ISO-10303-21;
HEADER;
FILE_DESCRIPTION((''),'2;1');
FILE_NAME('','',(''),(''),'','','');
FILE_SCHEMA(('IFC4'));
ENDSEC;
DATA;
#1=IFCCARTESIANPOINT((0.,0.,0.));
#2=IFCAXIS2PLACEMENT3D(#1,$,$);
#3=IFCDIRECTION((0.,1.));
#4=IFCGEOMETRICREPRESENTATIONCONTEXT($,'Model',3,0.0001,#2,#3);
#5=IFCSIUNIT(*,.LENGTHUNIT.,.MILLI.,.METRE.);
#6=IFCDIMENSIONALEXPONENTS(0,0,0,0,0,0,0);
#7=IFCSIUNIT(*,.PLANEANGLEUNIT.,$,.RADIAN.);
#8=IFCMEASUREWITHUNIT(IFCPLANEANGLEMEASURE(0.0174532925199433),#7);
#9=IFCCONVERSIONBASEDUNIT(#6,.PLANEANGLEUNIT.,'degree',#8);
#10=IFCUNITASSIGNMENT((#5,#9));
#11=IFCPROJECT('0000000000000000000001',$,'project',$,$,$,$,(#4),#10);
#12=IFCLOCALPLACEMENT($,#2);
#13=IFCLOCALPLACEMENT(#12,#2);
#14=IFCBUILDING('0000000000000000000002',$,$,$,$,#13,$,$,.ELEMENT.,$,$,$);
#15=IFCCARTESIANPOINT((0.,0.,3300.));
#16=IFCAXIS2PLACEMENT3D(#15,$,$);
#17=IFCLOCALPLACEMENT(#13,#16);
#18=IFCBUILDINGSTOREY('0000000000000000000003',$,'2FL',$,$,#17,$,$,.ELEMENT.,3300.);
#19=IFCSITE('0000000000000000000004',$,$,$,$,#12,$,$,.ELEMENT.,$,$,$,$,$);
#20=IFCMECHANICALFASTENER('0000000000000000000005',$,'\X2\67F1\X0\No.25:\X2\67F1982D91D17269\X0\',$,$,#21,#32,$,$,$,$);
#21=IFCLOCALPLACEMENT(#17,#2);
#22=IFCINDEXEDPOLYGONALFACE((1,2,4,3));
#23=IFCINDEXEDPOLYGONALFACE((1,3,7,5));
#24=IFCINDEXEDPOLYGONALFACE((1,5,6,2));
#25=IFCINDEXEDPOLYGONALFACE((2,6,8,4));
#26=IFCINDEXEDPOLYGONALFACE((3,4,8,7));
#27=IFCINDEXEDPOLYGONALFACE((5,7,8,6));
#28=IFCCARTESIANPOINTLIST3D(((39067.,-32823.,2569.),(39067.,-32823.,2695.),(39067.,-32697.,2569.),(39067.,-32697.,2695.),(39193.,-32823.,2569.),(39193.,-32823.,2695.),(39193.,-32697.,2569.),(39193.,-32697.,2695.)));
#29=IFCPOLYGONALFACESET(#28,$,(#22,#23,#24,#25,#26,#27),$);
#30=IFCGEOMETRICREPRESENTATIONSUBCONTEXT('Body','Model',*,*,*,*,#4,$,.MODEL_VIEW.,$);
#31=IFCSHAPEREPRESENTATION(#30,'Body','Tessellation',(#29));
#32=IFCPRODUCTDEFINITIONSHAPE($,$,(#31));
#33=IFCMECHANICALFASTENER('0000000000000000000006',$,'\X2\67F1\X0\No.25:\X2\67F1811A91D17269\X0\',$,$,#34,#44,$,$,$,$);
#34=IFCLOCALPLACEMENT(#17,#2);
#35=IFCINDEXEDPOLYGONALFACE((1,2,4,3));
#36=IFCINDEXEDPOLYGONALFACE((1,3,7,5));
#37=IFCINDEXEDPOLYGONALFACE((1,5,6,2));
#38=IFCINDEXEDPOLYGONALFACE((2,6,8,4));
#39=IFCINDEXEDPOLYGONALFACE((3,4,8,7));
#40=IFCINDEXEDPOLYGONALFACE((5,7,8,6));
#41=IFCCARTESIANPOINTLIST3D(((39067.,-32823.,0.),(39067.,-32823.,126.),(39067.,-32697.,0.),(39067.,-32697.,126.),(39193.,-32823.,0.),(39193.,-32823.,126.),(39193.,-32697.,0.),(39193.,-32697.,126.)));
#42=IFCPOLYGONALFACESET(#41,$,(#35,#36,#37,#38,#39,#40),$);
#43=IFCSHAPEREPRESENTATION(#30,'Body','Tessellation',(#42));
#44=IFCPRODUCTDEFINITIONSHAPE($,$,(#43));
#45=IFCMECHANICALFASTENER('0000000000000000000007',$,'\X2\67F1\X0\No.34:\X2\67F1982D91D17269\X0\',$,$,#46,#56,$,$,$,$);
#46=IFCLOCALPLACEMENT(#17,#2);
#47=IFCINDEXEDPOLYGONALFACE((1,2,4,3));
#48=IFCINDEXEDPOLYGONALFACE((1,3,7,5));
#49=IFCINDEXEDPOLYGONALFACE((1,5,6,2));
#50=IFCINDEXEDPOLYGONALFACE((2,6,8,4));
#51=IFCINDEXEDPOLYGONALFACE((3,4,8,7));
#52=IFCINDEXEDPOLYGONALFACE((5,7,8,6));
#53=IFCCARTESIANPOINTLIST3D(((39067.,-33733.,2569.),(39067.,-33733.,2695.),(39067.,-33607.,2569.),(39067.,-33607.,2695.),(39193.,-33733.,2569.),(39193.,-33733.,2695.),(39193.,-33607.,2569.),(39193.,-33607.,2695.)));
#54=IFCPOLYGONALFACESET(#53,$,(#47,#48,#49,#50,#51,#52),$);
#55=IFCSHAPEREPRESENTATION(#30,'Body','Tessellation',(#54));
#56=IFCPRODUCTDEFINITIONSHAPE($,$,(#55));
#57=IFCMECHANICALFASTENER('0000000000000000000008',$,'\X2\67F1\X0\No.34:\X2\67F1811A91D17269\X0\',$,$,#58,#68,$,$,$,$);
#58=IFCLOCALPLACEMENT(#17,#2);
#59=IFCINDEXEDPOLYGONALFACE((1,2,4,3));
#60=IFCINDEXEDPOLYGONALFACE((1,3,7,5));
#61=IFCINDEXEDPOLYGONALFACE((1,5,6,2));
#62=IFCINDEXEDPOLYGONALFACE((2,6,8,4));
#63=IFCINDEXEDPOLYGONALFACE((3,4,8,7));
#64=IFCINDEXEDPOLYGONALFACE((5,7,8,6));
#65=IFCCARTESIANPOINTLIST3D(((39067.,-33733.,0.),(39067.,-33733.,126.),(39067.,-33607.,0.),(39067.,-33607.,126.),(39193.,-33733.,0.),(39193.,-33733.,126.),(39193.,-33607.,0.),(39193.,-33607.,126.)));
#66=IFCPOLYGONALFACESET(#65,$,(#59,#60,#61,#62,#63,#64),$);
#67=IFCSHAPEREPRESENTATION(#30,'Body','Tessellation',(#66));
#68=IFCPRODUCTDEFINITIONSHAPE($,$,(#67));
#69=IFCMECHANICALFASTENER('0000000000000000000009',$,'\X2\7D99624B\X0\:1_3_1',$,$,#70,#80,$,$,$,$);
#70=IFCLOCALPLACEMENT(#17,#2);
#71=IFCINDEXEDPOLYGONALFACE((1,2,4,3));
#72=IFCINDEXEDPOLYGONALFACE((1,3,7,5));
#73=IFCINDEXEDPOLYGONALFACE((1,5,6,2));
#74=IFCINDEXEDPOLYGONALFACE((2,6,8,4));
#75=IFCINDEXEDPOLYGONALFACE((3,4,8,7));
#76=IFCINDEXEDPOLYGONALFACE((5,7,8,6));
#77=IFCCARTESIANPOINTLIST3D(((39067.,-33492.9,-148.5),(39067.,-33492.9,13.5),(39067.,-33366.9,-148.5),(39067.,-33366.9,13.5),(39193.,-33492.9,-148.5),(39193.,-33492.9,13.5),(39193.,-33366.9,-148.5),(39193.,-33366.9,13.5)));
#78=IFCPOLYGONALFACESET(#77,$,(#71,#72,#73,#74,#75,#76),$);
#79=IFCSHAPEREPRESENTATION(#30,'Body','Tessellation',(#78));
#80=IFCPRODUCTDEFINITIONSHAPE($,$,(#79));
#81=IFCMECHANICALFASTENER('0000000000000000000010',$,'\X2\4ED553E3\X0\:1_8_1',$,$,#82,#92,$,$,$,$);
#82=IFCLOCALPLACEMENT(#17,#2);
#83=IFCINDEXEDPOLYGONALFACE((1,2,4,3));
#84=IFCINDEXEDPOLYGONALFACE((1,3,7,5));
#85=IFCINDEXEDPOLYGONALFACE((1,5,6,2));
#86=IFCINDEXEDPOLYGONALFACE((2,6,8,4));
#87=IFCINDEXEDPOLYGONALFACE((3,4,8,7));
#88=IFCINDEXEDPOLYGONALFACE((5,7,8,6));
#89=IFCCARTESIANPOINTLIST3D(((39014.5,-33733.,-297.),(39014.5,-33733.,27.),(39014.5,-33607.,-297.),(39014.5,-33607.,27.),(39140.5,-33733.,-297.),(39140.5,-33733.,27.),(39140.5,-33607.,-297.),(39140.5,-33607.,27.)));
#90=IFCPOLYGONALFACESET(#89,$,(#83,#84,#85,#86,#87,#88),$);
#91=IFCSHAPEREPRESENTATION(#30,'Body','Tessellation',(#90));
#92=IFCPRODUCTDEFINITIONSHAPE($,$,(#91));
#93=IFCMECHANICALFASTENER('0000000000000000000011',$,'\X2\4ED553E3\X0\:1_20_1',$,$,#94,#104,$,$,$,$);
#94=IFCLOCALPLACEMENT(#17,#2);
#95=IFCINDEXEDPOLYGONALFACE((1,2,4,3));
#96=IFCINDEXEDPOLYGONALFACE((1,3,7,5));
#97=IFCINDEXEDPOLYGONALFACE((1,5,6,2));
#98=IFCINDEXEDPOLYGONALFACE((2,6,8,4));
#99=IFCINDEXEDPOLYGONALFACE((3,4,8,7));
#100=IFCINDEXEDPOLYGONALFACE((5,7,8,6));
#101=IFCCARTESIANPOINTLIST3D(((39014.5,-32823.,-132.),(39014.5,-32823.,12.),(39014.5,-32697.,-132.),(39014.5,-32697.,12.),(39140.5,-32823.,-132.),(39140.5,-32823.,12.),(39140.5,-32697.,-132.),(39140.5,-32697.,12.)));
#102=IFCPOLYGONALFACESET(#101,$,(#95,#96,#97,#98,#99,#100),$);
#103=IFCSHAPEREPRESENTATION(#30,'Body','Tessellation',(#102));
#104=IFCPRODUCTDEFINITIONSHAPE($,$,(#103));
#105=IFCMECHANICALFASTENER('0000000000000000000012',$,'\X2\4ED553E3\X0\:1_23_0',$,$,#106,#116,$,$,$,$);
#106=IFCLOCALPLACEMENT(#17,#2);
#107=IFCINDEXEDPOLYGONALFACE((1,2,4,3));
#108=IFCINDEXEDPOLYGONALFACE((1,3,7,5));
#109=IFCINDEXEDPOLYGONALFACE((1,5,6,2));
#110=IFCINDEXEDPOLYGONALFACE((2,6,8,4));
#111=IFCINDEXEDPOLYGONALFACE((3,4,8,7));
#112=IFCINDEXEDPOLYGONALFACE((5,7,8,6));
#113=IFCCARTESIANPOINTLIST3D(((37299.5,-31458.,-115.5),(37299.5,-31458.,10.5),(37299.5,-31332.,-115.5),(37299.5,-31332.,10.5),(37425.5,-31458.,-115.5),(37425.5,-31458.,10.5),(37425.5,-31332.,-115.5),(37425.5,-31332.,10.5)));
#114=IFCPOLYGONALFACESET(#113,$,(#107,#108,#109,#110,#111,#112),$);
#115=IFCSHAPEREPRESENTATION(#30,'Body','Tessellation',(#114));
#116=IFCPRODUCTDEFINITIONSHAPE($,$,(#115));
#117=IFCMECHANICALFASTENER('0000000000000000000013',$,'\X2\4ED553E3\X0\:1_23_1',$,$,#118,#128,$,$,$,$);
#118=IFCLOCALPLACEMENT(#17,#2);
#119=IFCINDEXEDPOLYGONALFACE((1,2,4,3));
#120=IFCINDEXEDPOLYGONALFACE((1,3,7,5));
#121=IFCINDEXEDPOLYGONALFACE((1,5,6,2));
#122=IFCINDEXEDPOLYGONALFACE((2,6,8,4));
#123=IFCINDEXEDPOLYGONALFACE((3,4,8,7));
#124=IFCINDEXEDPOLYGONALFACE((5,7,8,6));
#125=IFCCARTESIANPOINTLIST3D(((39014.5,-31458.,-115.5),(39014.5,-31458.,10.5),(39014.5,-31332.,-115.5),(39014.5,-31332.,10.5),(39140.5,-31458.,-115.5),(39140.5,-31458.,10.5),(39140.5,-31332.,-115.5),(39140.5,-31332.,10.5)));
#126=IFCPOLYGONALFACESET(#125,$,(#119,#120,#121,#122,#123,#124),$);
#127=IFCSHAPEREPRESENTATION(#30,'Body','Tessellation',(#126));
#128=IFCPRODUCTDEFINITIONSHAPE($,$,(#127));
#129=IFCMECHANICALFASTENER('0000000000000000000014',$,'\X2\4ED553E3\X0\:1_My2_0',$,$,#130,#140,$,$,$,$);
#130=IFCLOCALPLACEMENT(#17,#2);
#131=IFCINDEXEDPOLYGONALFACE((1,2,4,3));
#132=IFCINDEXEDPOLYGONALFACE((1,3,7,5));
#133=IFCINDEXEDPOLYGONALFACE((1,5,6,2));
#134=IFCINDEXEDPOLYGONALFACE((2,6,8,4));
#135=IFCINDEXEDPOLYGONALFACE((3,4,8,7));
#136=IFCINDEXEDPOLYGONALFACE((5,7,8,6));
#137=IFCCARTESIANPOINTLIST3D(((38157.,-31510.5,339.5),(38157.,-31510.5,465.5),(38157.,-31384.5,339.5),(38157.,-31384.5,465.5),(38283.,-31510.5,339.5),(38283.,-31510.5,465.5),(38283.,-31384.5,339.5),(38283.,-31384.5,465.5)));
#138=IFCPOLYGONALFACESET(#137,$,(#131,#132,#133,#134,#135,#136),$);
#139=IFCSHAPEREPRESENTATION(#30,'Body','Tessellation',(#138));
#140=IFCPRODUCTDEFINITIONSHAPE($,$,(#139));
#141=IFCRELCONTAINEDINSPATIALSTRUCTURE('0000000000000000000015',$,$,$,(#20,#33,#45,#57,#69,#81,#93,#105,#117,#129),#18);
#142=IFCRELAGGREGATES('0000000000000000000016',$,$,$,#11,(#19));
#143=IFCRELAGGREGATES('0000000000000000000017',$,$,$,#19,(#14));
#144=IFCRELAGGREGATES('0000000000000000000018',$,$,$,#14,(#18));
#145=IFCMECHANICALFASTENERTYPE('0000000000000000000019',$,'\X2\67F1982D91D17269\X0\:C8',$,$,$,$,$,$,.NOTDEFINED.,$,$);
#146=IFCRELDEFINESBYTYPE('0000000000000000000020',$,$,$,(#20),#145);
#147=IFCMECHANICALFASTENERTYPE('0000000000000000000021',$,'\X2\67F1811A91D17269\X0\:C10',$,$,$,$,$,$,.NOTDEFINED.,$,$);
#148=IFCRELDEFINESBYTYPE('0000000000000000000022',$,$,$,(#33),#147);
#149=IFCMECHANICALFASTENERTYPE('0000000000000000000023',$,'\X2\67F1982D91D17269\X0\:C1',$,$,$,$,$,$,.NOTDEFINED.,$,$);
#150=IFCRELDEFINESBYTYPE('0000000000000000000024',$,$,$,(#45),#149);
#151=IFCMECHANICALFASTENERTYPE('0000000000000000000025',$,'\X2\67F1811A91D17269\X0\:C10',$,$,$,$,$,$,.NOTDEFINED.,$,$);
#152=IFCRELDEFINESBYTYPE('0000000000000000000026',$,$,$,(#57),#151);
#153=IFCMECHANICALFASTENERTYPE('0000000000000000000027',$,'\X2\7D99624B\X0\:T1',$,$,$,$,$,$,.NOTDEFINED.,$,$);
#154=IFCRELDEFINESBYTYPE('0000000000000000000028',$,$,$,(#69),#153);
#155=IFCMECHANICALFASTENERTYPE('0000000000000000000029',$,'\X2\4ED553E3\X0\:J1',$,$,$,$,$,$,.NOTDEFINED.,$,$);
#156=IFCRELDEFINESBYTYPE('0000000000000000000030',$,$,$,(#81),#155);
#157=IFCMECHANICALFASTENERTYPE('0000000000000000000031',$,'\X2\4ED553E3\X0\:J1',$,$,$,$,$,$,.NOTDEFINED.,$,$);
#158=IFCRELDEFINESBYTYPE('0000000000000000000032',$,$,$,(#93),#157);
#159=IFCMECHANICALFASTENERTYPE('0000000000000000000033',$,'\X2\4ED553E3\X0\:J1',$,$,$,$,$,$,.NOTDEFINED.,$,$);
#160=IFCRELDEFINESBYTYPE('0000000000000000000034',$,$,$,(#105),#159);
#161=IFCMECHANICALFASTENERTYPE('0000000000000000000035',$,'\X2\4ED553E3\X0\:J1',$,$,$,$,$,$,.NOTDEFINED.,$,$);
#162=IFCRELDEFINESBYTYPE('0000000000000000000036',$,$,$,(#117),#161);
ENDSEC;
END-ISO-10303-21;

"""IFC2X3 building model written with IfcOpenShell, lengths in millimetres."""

from ifc_helpers import new_model, entity, si_unit, converted_unit, direction, frame, origin, origin_with_axes, origin_2d, place, context, subcontext, project, spatial, rectangle, extrude, type_object, element, save


model = new_model("IFC2X3")

# Units and contexts
model_context = context("Model", 3, precision=0.0001, world=origin(), true_north=direction((0.0, 1.0)))
body_context = subcontext(model_context, "Body", "Model", "MODEL_VIEW")
ifc_project = project(units=[si_unit("LENGTHUNIT", "METRE", prefix="MILLI"), converted_unit("PLANEANGLEUNIT", "degree", entity("IfcPlaneAngleMeasure", 0.0174532925199433), si_unit("PLANEANGLEUNIT", "RADIAN"), dimensions=[0, 0, 0, 0, 0, 0, 0])], contexts=[model_context])

# Site, building, storey
site_placement = place(None, origin())
site = spatial("IfcSite", under=ifc_project, at=site_placement, CompositionType="ELEMENT")
building_placement = place(site_placement, origin())
building = spatial("IfcBuilding", under=site, at=building_placement, CompositionType="ELEMENT")
storey_placement = place(building_placement, frame((0.0, 0.0, 3300.0)))
storey = spatial("IfcBuildingStorey", under=building, at=storey_placement, Name="2FL", CompositionType="ELEMENT", Elevation=3300.0)

# Mechanical fasteners
mechanical_fastener_type_1 = type_object("IfcMechanicalFastenerType", Name="柱頭金物:C8")
mechanical_fastener_1_placement = place(storey_placement, frame((39130.0, -32760.0, 2569.0)))
element("IfcMechanicalFastener", 1, at=mechanical_fastener_1_placement, inside=storey, type_object=mechanical_fastener_type_1, Name="柱No.25:柱頭金物", context=body_context, shape_type="SweptSolid", body=[
    extrude(rectangle(XDim=126.0, YDim=126.0, at=origin_2d()), origin_with_axes(), (0.0, 0.0, 1.0), 126.0),
])
mechanical_fastener_type_2 = type_object("IfcMechanicalFastenerType", Name="柱脚金物:C10")
mechanical_fastener_2_placement = place(storey_placement, frame((39130.0, -32760.0, 0.0)))
element("IfcMechanicalFastener", 2, at=mechanical_fastener_2_placement, inside=storey, type_object=mechanical_fastener_type_2, Name="柱No.25:柱脚金物", context=body_context, shape_type="SweptSolid", body=[
    extrude(rectangle(XDim=126.0, YDim=126.0, at=origin_2d()), origin_with_axes(), (0.0, 0.0, 1.0), 126.0),
])
mechanical_fastener_type_3 = type_object("IfcMechanicalFastenerType", Name="柱頭金物:C1")
mechanical_fastener_3_placement = place(storey_placement, frame((39130.0, -33670.0, 2569.0)))
element("IfcMechanicalFastener", 3, at=mechanical_fastener_3_placement, inside=storey, type_object=mechanical_fastener_type_3, Name="柱No.34:柱頭金物", context=body_context, shape_type="SweptSolid", body=[
    extrude(rectangle(XDim=126.0, YDim=126.0, at=origin_2d()), origin_with_axes(), (0.0, 0.0, 1.0), 126.0),
])
mechanical_fastener_type_4 = type_object("IfcMechanicalFastenerType", Name="柱脚金物:C10")
mechanical_fastener_4_placement = place(storey_placement, frame((39130.0, -33670.0, 0.0)))
element("IfcMechanicalFastener", 4, at=mechanical_fastener_4_placement, inside=storey, type_object=mechanical_fastener_type_4, Name="柱No.34:柱脚金物", context=body_context, shape_type="SweptSolid", body=[
    extrude(rectangle(XDim=126.0, YDim=126.0, at=origin_2d()), origin_with_axes(), (0.0, 0.0, 1.0), 126.0),
])
mechanical_fastener_type_5 = type_object("IfcMechanicalFastenerType", Name="継手:T1")
mechanical_fastener_5_placement = place(storey_placement, frame((39130.0, -33429.9, -148.5)))
element("IfcMechanicalFastener", 5, at=mechanical_fastener_5_placement, inside=storey, type_object=mechanical_fastener_type_5, Name="継手:1_3_1", context=body_context, shape_type="SweptSolid", body=[
    extrude(rectangle(XDim=126.0, YDim=126.0, at=origin_2d()), origin_with_axes(), (0.0, 0.0, 1.0), 162.0),
])
mechanical_fastener_type_6 = type_object("IfcMechanicalFastenerType", Name="仕口:J1")
mechanical_fastener_6_placement = place(storey_placement, frame((39077.5, -33670.0, -297.0)))
element("IfcMechanicalFastener", 6, at=mechanical_fastener_6_placement, inside=storey, type_object=mechanical_fastener_type_6, Name="仕口:1_8_1", context=body_context, shape_type="SweptSolid", body=[
    extrude(rectangle(XDim=126.0, YDim=126.0, at=origin_2d()), origin_with_axes(), (0.0, 0.0, 1.0), 324.0),
])
mechanical_fastener_type_7 = type_object("IfcMechanicalFastenerType", Name="仕口:J1")
mechanical_fastener_7_placement = place(storey_placement, frame((39077.5, -32760.0, -132.0)))
element("IfcMechanicalFastener", 7, at=mechanical_fastener_7_placement, inside=storey, type_object=mechanical_fastener_type_7, Name="仕口:1_20_1", context=body_context, shape_type="SweptSolid", body=[
    extrude(rectangle(XDim=126.0, YDim=126.0, at=origin_2d()), origin_with_axes(), (0.0, 0.0, 1.0), 144.0),
])
mechanical_fastener_type_8 = type_object("IfcMechanicalFastenerType", Name="仕口:J1")
mechanical_fastener_8_placement = place(storey_placement, frame((37362.5, -31395.0, -115.5)))
element("IfcMechanicalFastener", 8, at=mechanical_fastener_8_placement, inside=storey, type_object=mechanical_fastener_type_8, Name="仕口:1_23_0", context=body_context, shape_type="SweptSolid", body=[
    extrude(rectangle(XDim=126.0, YDim=126.0, at=origin_2d()), origin_with_axes(), (0.0, 0.0, 1.0), 126.0),
])
mechanical_fastener_type_9 = type_object("IfcMechanicalFastenerType", Name="仕口:J1")
mechanical_fastener_9_placement = place(storey_placement, frame((39077.5, -31395.0, -115.5)))
element("IfcMechanicalFastener", 9, at=mechanical_fastener_9_placement, inside=storey, type_object=mechanical_fastener_type_9, Name="仕口:1_23_1", context=body_context, shape_type="SweptSolid", body=[
    extrude(rectangle(XDim=126.0, YDim=126.0, at=origin_2d()), origin_with_axes(), (0.0, 0.0, 1.0), 126.0),
])
mechanical_fastener_10_placement = place(storey_placement, frame((38220.0, -31447.5, 339.5)))
element("IfcMechanicalFastener", 10, at=mechanical_fastener_10_placement, inside=storey, Name="仕口:1_My2_0", context=body_context, shape_type="SweptSolid", body=[
    extrude(rectangle(XDim=126.0, YDim=126.0, at=origin_2d()), origin_with_axes(), (0.0, 0.0, 1.0), 126.0),
])

save(model, "model.ifc")
